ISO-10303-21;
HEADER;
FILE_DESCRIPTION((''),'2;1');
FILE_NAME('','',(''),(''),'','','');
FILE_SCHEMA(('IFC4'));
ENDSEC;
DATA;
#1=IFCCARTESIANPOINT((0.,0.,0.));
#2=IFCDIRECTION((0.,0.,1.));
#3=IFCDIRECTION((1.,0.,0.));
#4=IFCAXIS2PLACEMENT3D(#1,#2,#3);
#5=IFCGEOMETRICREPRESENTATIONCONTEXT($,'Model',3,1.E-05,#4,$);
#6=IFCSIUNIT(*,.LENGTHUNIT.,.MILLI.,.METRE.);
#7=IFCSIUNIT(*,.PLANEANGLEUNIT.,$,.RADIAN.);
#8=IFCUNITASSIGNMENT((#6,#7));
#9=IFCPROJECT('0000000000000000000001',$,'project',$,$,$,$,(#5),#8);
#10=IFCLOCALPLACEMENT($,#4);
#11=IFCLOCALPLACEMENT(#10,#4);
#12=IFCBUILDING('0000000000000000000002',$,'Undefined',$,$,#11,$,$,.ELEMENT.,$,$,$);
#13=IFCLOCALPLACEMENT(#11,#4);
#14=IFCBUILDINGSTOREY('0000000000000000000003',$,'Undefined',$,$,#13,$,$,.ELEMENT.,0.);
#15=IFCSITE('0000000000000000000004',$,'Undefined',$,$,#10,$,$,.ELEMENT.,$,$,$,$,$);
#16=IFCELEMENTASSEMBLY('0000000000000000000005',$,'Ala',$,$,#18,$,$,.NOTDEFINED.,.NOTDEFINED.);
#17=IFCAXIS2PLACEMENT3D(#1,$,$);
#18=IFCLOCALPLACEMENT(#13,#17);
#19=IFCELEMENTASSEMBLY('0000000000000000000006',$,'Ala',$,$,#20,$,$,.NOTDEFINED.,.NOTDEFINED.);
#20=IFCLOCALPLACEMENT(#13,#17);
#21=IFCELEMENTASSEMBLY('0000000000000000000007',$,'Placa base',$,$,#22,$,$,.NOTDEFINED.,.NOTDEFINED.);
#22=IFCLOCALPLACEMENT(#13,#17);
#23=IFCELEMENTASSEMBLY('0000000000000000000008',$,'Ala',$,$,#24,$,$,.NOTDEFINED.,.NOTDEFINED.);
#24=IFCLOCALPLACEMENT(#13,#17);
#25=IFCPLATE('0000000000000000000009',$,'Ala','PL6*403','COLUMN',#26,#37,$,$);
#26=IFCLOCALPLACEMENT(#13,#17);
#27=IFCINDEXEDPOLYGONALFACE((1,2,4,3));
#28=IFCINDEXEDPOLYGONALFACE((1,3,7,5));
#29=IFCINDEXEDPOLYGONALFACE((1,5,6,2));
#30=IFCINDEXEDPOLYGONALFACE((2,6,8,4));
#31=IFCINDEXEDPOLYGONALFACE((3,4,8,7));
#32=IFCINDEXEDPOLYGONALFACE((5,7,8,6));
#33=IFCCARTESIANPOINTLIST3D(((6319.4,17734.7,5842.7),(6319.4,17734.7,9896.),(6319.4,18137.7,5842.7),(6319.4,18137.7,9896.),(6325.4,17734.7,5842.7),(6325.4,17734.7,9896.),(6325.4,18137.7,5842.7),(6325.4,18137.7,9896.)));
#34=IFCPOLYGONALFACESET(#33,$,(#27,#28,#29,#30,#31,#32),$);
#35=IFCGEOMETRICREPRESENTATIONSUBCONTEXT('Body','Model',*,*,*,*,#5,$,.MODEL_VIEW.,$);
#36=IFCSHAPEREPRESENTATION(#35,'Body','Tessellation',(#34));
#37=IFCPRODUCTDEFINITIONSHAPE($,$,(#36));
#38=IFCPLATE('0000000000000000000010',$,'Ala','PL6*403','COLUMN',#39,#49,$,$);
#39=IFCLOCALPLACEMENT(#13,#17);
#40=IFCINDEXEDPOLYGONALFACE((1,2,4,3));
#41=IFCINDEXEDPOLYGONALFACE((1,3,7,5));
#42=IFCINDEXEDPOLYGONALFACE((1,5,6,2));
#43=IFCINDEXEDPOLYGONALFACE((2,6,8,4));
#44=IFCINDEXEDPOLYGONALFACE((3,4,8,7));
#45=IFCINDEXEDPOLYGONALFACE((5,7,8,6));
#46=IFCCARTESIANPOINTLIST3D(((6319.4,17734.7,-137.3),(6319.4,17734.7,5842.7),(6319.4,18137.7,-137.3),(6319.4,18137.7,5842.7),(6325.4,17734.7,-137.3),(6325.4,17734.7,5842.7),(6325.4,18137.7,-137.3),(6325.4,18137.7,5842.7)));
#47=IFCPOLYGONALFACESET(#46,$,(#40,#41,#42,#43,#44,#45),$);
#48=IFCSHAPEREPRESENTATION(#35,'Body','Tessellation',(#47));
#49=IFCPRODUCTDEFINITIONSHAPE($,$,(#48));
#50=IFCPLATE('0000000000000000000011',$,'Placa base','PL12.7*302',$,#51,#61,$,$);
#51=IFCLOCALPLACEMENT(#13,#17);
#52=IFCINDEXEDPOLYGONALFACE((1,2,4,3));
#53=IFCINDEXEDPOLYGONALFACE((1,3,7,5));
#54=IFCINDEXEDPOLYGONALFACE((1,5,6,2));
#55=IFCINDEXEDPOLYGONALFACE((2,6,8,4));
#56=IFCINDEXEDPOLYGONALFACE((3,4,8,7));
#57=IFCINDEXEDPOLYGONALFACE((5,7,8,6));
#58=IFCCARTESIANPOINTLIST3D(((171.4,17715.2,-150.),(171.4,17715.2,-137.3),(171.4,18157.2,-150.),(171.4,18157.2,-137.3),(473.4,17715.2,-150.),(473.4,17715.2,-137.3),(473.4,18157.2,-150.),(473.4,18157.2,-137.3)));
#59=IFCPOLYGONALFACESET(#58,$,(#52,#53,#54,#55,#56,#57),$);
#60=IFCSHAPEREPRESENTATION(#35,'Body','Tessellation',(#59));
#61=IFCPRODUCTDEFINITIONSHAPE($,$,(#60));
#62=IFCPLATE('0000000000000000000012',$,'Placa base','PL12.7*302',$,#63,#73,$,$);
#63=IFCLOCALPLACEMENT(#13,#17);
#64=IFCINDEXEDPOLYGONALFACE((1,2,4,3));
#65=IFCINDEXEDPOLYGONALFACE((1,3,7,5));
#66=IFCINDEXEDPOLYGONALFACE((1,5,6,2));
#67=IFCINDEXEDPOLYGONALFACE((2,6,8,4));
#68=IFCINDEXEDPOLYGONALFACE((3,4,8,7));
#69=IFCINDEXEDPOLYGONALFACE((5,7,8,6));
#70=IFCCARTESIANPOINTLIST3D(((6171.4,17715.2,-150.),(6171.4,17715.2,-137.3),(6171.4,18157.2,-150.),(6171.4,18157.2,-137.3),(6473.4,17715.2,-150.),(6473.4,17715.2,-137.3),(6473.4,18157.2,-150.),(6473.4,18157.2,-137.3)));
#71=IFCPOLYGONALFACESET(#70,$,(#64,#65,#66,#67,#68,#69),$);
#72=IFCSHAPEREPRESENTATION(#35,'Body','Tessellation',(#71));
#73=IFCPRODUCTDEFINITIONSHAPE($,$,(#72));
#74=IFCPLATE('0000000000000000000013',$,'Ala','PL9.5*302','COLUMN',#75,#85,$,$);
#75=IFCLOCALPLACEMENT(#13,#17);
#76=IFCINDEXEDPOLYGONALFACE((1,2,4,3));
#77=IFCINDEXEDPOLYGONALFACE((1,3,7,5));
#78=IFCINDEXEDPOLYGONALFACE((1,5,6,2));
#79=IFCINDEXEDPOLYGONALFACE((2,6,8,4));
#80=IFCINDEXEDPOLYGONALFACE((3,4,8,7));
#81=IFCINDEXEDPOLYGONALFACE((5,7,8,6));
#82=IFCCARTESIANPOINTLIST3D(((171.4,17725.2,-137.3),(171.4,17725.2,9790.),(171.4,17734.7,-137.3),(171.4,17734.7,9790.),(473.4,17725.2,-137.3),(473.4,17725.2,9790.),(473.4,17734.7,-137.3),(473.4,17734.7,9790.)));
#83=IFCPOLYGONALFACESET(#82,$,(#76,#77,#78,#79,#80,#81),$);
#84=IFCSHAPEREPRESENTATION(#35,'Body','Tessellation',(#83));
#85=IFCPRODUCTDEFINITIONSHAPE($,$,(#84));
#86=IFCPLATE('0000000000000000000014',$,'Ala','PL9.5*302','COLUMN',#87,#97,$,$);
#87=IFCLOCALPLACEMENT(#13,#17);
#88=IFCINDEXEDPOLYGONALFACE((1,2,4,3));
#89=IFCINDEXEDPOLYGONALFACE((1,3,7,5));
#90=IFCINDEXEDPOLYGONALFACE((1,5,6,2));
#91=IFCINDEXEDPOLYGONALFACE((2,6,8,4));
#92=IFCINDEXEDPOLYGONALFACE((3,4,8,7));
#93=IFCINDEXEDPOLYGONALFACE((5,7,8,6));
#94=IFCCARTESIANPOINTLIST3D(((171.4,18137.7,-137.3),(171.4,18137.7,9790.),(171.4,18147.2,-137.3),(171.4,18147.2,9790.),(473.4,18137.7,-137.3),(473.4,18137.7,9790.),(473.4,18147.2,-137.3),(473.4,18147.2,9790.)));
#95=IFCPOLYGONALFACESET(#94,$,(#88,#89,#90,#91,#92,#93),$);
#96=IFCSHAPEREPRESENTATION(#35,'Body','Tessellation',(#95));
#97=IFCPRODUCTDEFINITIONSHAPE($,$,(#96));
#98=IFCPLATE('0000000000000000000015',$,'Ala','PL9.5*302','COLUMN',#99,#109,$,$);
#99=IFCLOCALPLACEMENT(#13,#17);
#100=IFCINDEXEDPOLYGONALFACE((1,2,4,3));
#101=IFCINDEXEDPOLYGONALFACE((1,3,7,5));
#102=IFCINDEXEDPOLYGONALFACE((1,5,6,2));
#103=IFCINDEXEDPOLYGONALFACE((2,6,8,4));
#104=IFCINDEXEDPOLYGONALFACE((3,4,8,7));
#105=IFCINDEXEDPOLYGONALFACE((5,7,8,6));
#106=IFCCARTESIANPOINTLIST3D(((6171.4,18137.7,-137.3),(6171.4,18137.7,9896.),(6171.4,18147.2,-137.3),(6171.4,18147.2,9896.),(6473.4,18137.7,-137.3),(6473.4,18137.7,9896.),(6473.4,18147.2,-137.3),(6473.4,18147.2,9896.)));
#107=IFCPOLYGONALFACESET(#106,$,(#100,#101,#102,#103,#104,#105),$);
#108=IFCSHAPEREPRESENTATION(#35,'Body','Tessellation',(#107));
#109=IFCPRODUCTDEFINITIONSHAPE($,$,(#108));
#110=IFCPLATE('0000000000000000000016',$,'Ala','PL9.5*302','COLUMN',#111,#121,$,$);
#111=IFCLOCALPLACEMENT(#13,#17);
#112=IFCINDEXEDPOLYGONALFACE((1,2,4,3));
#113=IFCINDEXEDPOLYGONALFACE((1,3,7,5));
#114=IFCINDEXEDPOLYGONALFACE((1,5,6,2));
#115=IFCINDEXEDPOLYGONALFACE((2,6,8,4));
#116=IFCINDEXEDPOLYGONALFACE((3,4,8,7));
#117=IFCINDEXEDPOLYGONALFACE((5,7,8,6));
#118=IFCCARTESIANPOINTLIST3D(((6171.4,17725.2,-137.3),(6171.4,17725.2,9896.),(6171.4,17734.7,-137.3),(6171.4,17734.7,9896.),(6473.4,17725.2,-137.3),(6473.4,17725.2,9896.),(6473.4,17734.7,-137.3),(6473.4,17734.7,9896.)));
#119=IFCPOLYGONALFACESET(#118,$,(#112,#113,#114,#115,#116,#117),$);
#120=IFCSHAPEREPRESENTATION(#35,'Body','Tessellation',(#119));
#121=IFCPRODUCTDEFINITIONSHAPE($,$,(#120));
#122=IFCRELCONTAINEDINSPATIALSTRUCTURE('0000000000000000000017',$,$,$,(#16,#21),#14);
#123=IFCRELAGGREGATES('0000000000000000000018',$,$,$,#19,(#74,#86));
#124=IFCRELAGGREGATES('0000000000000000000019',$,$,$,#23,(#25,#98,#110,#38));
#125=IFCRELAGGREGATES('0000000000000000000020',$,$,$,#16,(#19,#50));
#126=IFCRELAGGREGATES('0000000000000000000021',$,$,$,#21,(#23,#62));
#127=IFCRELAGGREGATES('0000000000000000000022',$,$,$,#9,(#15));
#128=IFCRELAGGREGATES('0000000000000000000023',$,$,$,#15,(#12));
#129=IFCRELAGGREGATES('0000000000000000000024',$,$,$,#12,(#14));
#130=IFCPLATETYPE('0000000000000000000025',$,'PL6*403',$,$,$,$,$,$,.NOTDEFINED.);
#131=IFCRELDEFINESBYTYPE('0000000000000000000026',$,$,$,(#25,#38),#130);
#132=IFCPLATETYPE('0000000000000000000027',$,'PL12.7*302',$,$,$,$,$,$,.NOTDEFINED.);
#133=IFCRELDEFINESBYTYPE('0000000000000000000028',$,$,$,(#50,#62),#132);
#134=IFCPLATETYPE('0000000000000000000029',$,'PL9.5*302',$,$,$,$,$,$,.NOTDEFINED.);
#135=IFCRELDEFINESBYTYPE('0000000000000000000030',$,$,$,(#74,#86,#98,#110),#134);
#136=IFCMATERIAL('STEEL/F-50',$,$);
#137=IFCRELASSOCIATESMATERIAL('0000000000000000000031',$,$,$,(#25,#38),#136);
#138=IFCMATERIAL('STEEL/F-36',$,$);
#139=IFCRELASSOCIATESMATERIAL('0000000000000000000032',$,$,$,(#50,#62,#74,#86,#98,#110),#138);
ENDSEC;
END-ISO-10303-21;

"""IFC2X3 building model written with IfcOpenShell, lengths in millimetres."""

from ifc_helpers import new_model, si_unit, frame, origin_with_axes, place, context, subcontext, project, spatial, polyline, outline, extrude, material, type_object, element, aggregate, save


model = new_model("IFC2X3")

# Units and contexts
model_context = context("Model", 3, precision=1e-05, world=origin_with_axes())
body_context = subcontext(model_context, "Body", "Model", "MODEL_VIEW")
ifc_project = project(units=[si_unit("LENGTHUNIT", "METRE", prefix="MILLI"), si_unit("PLANEANGLEUNIT", "RADIAN")], contexts=[model_context])

# Site, building, storey
site_placement = place(None, origin_with_axes())
site = spatial("IfcSite", under=ifc_project, at=site_placement, Name="Undefined", CompositionType="ELEMENT")
building_placement = place(site_placement, origin_with_axes())
building = spatial("IfcBuilding", under=site, at=building_placement, Name="Undefined", CompositionType="ELEMENT")
storey_placement = place(building_placement, origin_with_axes())
storey = spatial("IfcBuildingStorey", under=building, at=storey_placement, Name="Undefined", CompositionType="ELEMENT", Elevation=0.0)

# Shared definitions
ifc_material_1 = material(Name="STEEL/F-50")

# Shared definitions
ifc_material_2 = material(Name="STEEL/F-36")

# Element assemblies, plates
assembly_1_placement = place(storey_placement, origin_with_axes())
assembly_1 = element("IfcElementAssembly", 1, at=assembly_1_placement, inside=storey, Name="Ala", AssemblyPlace="NOTDEFINED", PredefinedType="NOTDEFINED")
assembly_2_placement = place(assembly_1_placement, origin_with_axes())
assembly_2 = element("IfcElementAssembly", 2, at=assembly_2_placement, Name="Ala", AssemblyPlace="NOTDEFINED", PredefinedType="NOTDEFINED")
plate_type_1 = type_object("IfcPlateType", Name="PL6*403", PredefinedType="NOTDEFINED")
assembly_3_placement = place(storey_placement, origin_with_axes())
assembly_3 = element("IfcElementAssembly", 3, at=assembly_3_placement, inside=storey, Name="Placa base", AssemblyPlace="NOTDEFINED", PredefinedType="NOTDEFINED")
assembly_4_placement = place(assembly_3_placement, origin_with_axes())
assembly_4 = element("IfcElementAssembly", 4, at=assembly_4_placement, Name="Ala", AssemblyPlace="NOTDEFINED", PredefinedType="NOTDEFINED")
plate_1_placement = place(assembly_4_placement, frame((6322.4, 17936.2, 5842.7), z_axis=(1.0, 0.0, 0.0), x_axis=(0.0, 0.0, 1.0)))
plate_1 = element("IfcPlate", 5, at=plate_1_placement, type_object=plate_type_1, material=ifc_material_1, Name="Ala", Description="PL6*403", ObjectType="COLUMN", context=body_context, shape_type="SweptSolid", body=[
    extrude(outline(polyline([(0.0, -201.5), (0.0, 201.5), (4053.3, 201.5), (4053.3, -201.5), (0.0, -201.5)])), frame((0.0, 0.0, -3.0), z_axis=(0.0, 0.0, 1.0), x_axis=(1.0, 0.0, 0.0)), (0.0, 0.0, 1.0), 6.0),
])
plate_2_placement = place(assembly_4_placement, frame((6322.4, 17936.2, -137.3), z_axis=(1.0, 0.0, 0.0), x_axis=(0.0, 0.0, 1.0)))
plate_2 = element("IfcPlate", 6, at=plate_2_placement, type_object=plate_type_1, material=ifc_material_1, Name="Ala", Description="PL6*403", ObjectType="COLUMN", context=body_context, shape_type="SweptSolid", body=[
    extrude(outline(polyline([(0.0, -201.5), (0.0, 201.5), (5980.0, 201.5), (5980.0, -201.5), (0.0, -201.5)])), frame((0.0, 0.0, -3.0), z_axis=(0.0, 0.0, 1.0), x_axis=(1.0, 0.0, 0.0)), (0.0, 0.0, 1.0), 6.0),
])

# Plates
plate_type_2 = type_object("IfcPlateType", Name="PL12.7*302", PredefinedType="NOTDEFINED")
plate_3_placement = place(assembly_1_placement, frame((322.4, 18157.2, -143.7), z_axis=(0.0, 0.0, 1.0), x_axis=(0.0, -1.0, 0.0)))
plate_3 = element("IfcPlate", 7, at=plate_3_placement, type_object=plate_type_2, material=ifc_material_2, Name="Placa base", Description="PL12.7*302", context=body_context, shape_type="SweptSolid", body=[
    extrude(outline(polyline([(0.0, -151.0), (0.0, 151.0), (442.0, 151.0), (442.0, -151.0), (0.0, -151.0)])), frame((0.0, 0.0, -6.3), z_axis=(0.0, 0.0, 1.0), x_axis=(1.0, 0.0, 0.0)), (0.0, 0.0, 1.0), 12.7),
])
plate_4_placement = place(assembly_3_placement, frame((6322.4, 17715.2, -143.7), z_axis=(0.0, 0.0, 1.0), x_axis=(0.0, 1.0, 0.0)))
plate_4 = element("IfcPlate", 8, at=plate_4_placement, type_object=plate_type_2, material=ifc_material_2, Name="Placa base", Description="PL12.7*302", context=body_context, shape_type="SweptSolid", body=[
    extrude(outline(polyline([(0.0, -151.0), (0.0, 151.0), (442.0, 151.0), (442.0, -151.0), (0.0, -151.0)])), frame((0.0, 0.0, -6.3), z_axis=(0.0, 0.0, 1.0), x_axis=(1.0, 0.0, 0.0)), (0.0, 0.0, 1.0), 12.7),
])
plate_type_3 = type_object("IfcPlateType", Name="PL9.5*302", PredefinedType="NOTDEFINED")
plate_5_placement = place(assembly_2_placement, frame((322.4, 17730.0, -137.3), z_axis=(0.0, 1.0, 0.0), x_axis=(0.0, 0.0, 1.0)))
plate_5 = element("IfcPlate", 9, at=plate_5_placement, type_object=plate_type_3, material=ifc_material_2, Name="Ala", Description="PL9.5*302", ObjectType="COLUMN", context=body_context, shape_type="SweptSolid", body=[
    extrude(outline(polyline([(0.0, -151.0), (0.0, 151.0), (9927.3, 151.0), (9927.3, -151.0), (0.0, -151.0)])), frame((0.0, 0.0, -4.8), z_axis=(0.0, 0.0, 1.0), x_axis=(1.0, 0.0, 0.0)), (0.0, 0.0, 1.0), 9.5),
])
plate_6_placement = place(assembly_2_placement, frame((322.4, 18142.5, -137.3), z_axis=(0.0, 1.0, 0.0), x_axis=(0.0, 0.0, 1.0)))
plate_6 = element("IfcPlate", 10, at=plate_6_placement, type_object=plate_type_3, material=ifc_material_2, Name="Ala", Description="PL9.5*302", ObjectType="COLUMN", context=body_context, shape_type="SweptSolid", body=[
    extrude(outline(polyline([(0.0, -151.0), (0.0, 151.0), (9927.3, 151.0), (9927.3, -151.0), (0.0, -151.0)])), frame((0.0, 0.0, -4.8), z_axis=(0.0, 0.0, 1.0), x_axis=(1.0, 0.0, 0.0)), (0.0, 0.0, 1.0), 9.5),
])
aggregate(assembly_2, [plate_5, plate_6])
plate_7_placement = place(assembly_4_placement, frame((6322.4, 18142.4, -137.3), z_axis=(0.0, -1.0, 0.0), x_axis=(0.0, 0.0, 1.0)))
plate_7 = element("IfcPlate", 11, at=plate_7_placement, type_object=plate_type_3, material=ifc_material_2, Name="Ala", Description="PL9.5*302", ObjectType="COLUMN", context=body_context, shape_type="SweptSolid", body=[
    extrude(outline(polyline([(0.0, -151.0), (0.0, 151.0), (10033.3, 151.0), (10033.3, -151.0), (0.0, -151.0)])), frame((0.0, 0.0, -4.8), z_axis=(0.0, 0.0, 1.0), x_axis=(1.0, 0.0, 0.0)), (0.0, 0.0, 1.0), 9.5),
])
plate_8_placement = place(assembly_4_placement, frame((6322.4, 17729.9, -137.3), z_axis=(0.0, -1.0, 0.0), x_axis=(0.0, 0.0, 1.0)))
plate_8 = element("IfcPlate", 12, at=plate_8_placement, type_object=plate_type_3, material=ifc_material_2, Name="Ala", Description="PL9.5*302", ObjectType="COLUMN", context=body_context, shape_type="SweptSolid", body=[
    extrude(outline(polyline([(0.0, -151.0), (0.0, 151.0), (10033.3, 151.0), (10033.3, -151.0), (0.0, -151.0)])), frame((0.0, 0.0, -4.8), z_axis=(0.0, 0.0, 1.0), x_axis=(1.0, 0.0, 0.0)), (0.0, 0.0, 1.0), 9.5),
])
aggregate(assembly_4, [plate_1, plate_7, plate_8, plate_2])

aggregate(assembly_1, [assembly_2, plate_3])
aggregate(assembly_3, [assembly_4, plate_4])

save(model, "model.ifc")
